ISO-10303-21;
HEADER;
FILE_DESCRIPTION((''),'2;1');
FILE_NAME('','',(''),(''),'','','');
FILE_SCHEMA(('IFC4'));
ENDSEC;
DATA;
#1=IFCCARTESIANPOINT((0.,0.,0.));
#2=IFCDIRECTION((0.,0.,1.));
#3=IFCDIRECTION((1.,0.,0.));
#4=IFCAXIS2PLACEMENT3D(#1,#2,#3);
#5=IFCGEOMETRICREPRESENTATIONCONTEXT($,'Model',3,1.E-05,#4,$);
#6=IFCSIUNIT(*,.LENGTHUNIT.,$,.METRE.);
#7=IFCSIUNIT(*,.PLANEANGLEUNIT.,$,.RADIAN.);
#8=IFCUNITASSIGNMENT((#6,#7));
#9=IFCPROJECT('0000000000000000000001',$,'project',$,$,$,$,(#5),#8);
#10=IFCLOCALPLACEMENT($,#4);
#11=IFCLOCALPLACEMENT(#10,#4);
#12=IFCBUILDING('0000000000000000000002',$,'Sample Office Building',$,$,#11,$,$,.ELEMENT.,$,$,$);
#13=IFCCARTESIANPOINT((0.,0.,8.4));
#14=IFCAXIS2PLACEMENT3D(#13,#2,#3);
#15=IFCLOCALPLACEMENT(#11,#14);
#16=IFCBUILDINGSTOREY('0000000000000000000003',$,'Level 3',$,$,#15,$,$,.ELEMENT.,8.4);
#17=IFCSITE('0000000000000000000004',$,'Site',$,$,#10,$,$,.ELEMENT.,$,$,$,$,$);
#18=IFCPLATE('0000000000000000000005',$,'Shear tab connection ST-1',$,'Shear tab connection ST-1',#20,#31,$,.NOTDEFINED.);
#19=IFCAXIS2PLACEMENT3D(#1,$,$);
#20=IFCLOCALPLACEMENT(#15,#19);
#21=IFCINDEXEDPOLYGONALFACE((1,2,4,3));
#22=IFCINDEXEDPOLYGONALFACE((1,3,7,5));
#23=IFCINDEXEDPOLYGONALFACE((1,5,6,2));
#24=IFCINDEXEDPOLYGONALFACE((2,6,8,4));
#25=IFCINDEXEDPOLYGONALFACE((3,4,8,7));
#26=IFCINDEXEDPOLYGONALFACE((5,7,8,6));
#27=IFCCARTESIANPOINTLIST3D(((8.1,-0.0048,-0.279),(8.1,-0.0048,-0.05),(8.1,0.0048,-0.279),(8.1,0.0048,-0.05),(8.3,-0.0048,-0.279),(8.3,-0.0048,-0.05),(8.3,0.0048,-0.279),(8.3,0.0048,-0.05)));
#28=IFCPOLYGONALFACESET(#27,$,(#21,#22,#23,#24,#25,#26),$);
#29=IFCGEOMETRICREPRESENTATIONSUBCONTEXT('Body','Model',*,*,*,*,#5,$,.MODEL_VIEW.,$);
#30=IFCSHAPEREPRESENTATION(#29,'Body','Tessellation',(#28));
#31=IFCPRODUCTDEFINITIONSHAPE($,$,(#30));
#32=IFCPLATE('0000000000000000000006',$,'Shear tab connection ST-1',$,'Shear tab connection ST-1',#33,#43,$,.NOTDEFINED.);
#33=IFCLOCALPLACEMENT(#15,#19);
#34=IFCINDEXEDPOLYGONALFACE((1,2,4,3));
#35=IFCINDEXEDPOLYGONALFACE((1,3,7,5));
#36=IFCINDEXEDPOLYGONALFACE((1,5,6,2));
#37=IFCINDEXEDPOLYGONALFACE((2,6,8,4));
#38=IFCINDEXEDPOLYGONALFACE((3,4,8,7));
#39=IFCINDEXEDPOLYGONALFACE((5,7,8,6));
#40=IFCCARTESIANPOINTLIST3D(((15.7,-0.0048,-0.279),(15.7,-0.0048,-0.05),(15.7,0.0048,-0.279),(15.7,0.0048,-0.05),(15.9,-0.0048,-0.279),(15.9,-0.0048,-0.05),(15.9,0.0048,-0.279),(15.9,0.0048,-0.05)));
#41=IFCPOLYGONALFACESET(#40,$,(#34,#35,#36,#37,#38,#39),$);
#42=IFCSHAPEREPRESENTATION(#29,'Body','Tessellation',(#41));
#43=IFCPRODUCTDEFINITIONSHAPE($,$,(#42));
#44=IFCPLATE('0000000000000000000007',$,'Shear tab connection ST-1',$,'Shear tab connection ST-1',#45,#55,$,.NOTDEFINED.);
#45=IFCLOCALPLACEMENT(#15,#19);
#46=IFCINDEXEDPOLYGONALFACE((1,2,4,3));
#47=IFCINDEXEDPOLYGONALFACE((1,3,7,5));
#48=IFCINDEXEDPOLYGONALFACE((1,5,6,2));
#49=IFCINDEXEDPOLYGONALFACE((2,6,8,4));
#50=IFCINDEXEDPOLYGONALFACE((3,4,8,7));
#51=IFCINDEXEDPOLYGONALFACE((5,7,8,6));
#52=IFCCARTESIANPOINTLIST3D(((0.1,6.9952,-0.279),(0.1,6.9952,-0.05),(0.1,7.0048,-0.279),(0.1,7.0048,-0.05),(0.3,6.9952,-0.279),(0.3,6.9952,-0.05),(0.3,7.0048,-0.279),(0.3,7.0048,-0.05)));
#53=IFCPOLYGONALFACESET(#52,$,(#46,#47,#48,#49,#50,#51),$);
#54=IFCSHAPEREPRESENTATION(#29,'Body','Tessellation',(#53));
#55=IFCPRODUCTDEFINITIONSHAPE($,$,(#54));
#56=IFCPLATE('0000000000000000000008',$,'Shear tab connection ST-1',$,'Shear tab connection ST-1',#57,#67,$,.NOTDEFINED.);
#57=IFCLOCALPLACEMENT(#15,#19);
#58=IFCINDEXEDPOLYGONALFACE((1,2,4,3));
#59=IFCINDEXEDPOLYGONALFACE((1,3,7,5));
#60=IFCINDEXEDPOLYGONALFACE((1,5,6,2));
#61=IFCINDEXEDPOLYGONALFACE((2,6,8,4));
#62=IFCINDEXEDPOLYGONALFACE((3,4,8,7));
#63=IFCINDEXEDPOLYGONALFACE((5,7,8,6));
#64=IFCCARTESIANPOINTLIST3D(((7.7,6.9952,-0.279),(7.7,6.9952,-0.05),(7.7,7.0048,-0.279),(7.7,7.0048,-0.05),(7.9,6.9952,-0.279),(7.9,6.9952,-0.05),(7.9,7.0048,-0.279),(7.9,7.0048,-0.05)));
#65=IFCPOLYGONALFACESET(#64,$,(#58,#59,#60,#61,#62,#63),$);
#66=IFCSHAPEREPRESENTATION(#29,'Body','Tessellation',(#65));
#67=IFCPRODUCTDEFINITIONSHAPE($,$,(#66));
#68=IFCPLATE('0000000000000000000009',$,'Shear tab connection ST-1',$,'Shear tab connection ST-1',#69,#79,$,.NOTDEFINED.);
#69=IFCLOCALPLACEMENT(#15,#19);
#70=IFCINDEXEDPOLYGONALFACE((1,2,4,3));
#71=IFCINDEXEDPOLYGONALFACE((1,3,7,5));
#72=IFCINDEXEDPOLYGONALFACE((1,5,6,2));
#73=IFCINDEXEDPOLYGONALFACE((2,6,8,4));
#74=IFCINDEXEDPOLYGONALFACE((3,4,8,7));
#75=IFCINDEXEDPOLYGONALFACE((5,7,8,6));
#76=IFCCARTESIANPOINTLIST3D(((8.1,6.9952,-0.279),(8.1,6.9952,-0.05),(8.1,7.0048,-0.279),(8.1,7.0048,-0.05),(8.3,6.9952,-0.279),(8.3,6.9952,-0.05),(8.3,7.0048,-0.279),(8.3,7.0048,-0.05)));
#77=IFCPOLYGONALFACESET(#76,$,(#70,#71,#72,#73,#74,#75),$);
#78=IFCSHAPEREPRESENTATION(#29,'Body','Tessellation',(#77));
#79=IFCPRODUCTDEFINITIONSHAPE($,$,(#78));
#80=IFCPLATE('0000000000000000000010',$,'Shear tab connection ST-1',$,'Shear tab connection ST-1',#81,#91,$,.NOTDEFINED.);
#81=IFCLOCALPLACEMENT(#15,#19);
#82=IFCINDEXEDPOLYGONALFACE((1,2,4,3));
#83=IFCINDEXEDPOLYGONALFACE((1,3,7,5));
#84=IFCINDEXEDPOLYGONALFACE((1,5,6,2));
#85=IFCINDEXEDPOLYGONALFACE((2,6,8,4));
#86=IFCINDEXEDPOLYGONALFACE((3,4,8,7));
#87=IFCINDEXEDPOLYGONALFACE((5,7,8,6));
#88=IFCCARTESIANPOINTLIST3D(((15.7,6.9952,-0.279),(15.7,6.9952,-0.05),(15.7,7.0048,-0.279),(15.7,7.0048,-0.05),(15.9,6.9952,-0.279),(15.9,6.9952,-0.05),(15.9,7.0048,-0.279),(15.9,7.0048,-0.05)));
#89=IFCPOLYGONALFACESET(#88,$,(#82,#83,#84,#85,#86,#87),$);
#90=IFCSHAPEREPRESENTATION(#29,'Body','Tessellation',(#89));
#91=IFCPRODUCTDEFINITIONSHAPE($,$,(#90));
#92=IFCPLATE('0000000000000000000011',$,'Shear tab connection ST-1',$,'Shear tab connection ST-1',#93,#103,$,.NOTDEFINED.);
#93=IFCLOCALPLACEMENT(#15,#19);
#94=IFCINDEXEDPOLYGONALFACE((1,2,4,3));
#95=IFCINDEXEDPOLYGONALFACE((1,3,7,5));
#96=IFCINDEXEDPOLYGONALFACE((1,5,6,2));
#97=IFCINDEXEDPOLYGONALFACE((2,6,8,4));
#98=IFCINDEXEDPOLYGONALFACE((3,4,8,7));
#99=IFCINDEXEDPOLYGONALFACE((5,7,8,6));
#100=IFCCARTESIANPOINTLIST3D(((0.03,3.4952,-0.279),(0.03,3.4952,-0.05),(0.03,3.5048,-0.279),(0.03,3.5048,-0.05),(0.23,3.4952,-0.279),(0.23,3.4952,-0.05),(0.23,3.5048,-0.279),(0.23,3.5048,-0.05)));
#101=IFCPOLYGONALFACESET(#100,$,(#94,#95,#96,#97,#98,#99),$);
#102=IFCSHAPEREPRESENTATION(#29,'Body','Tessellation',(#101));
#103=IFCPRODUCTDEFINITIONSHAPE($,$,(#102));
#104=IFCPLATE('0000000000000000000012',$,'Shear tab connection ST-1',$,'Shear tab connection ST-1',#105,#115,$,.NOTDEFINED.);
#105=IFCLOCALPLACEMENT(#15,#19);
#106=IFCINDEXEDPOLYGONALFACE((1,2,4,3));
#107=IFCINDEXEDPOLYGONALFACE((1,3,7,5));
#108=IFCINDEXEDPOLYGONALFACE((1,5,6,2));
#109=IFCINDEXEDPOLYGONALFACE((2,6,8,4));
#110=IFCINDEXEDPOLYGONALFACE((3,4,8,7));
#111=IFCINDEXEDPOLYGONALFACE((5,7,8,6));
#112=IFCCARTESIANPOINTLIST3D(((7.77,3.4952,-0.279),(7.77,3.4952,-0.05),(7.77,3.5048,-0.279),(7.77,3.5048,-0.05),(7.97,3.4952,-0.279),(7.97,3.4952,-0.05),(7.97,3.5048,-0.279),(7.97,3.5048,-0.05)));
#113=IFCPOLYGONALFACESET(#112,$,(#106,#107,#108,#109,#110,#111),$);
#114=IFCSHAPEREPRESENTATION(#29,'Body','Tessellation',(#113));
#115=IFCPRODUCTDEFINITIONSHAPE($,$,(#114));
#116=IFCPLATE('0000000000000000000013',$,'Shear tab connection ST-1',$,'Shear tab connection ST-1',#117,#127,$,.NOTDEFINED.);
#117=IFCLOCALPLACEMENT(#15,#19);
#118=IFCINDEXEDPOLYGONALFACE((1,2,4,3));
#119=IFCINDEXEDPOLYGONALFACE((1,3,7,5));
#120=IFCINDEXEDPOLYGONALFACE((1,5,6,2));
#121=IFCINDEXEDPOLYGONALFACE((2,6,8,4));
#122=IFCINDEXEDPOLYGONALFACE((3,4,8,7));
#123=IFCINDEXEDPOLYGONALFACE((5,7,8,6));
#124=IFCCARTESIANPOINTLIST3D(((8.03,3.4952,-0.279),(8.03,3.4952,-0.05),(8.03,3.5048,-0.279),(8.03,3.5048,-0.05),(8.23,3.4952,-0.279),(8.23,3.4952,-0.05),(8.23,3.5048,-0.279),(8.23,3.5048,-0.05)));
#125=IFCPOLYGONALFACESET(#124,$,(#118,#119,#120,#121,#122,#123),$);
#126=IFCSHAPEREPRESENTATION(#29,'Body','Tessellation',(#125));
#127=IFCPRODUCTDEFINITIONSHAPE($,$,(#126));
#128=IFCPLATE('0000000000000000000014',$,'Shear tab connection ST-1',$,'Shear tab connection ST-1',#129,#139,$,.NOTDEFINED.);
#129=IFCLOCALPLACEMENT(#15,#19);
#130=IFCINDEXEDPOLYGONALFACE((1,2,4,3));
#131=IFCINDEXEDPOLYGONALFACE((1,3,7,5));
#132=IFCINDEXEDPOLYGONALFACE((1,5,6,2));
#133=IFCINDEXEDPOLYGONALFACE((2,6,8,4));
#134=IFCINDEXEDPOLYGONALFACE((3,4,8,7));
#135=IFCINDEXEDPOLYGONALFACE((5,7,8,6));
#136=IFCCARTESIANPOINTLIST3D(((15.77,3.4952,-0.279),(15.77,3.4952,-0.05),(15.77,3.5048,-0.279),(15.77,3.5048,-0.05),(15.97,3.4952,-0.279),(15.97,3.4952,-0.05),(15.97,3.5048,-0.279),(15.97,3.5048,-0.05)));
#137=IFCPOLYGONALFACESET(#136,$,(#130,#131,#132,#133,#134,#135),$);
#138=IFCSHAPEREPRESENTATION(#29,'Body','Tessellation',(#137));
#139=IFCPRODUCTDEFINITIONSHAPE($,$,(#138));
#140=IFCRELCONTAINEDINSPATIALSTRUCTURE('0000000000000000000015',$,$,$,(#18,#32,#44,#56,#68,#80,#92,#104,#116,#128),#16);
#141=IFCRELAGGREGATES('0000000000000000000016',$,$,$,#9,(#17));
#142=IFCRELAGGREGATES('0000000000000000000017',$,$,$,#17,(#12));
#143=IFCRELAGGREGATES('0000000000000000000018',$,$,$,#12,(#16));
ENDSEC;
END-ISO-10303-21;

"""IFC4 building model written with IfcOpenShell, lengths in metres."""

from ifc_helpers import new_model, si_unit, frame, origin_with_axes, place, context, subcontext, project, spatial, rectangle, extrude, element, save


model = new_model("IFC4")

# Units and contexts
model_context = context("Model", 3, precision=1e-05, world=origin_with_axes())
body_context = subcontext(model_context, "Body", "Model", "MODEL_VIEW")
ifc_project = project(units=[si_unit("LENGTHUNIT", "METRE"), si_unit("PLANEANGLEUNIT", "RADIAN")], contexts=[model_context])

# Site, building, storey
site_placement = place(None, origin_with_axes())
site = spatial("IfcSite", under=ifc_project, at=site_placement, Name="Site", CompositionType="ELEMENT")
building_placement = place(site_placement, origin_with_axes())
building = spatial("IfcBuilding", under=site, at=building_placement, Name="Sample Office Building", CompositionType="ELEMENT")
storey_placement = place(building_placement, frame((0.0, 0.0, 8.4), z_axis=(0.0, 0.0, 1.0), x_axis=(1.0, 0.0, 0.0)))
storey = spatial("IfcBuildingStorey", under=building, at=storey_placement, Name="Level 3", CompositionType="ELEMENT", Elevation=8.4)

# Plates
for number, where, z_axis, x_axis, name in (
    (1, (8.2, 0.0, 8.121), (0.0, 0.0, 1.0), (1.0, 0.0, 0.0), "Shear tab connection ST-1"),
    (2, (15.8, 0.0, 8.121), (0.0, 0.0, 1.0), (1.0, 0.0, 0.0), "Shear tab connection ST-1"),
):
    element("IfcPlate", number, at=place(None, frame(where, z_axis=z_axis, x_axis=x_axis)), inside=storey, Name=name, ObjectType="Shear tab connection ST-1", PredefinedType="NOTDEFINED", context=body_context, shape_type="SweptSolid", body=[
        extrude(rectangle(XDim=0.2, YDim=0.0095), None, (0.0, 0.0, 1.0), 0.229),
    ])
plate_1_placement = place(None, frame((0.2, 7.0, 8.121), z_axis=(0.0, 0.0, 1.0), x_axis=(1.0, 0.0, 0.0)))
element("IfcPlate", 3, at=plate_1_placement, inside=storey, Name="Shear tab connection ST-1", ObjectType="Shear tab connection ST-1", PredefinedType="NOTDEFINED", context=body_context, shape_type="SweptSolid", body=[
    extrude(rectangle(XDim=0.2, YDim=0.0095), None, (0.0, 0.0, 1.0), 0.229),
])
plate_2_placement = place(None, frame((7.8, 7.0, 8.121), z_axis=(0.0, 0.0, 1.0), x_axis=(1.0, 0.0, 0.0)))
element("IfcPlate", 4, at=plate_2_placement, inside=storey, Name="Shear tab connection ST-1", ObjectType="Shear tab connection ST-1", PredefinedType="NOTDEFINED", context=body_context, shape_type="SweptSolid", body=[
    extrude(rectangle(XDim=0.2, YDim=0.0095), None, (0.0, 0.0, 1.0), 0.229),
])
for number, where, z_axis, x_axis, name in (
    (5, (8.2, 7.0, 8.121), (0.0, 0.0, 1.0), (1.0, 0.0, 0.0), "Shear tab connection ST-1"),
    (6, (15.8, 7.0, 8.121), (0.0, 0.0, 1.0), (1.0, 0.0, 0.0), "Shear tab connection ST-1"),
):
    element("IfcPlate", number, at=place(None, frame(where, z_axis=z_axis, x_axis=x_axis)), inside=storey, Name=name, ObjectType="Shear tab connection ST-1", PredefinedType="NOTDEFINED", context=body_context, shape_type="SweptSolid", body=[
        extrude(rectangle(XDim=0.2, YDim=0.0095), None, (0.0, 0.0, 1.0), 0.229),
    ])
plate_3_placement = place(None, frame((0.13, 3.5, 8.121), z_axis=(0.0, 0.0, 1.0), x_axis=(1.0, 0.0, 0.0)))
element("IfcPlate", 7, at=plate_3_placement, inside=storey, Name="Shear tab connection ST-1", ObjectType="Shear tab connection ST-1", PredefinedType="NOTDEFINED", context=body_context, shape_type="SweptSolid", body=[
    extrude(rectangle(XDim=0.2, YDim=0.0095), None, (0.0, 0.0, 1.0), 0.229),
])
plate_4_placement = place(None, frame((7.87, 3.5, 8.121), z_axis=(0.0, 0.0, 1.0), x_axis=(1.0, 0.0, 0.0)))
element("IfcPlate", 8, at=plate_4_placement, inside=storey, Name="Shear tab connection ST-1", ObjectType="Shear tab connection ST-1", PredefinedType="NOTDEFINED", context=body_context, shape_type="SweptSolid", body=[
    extrude(rectangle(XDim=0.2, YDim=0.0095), None, (0.0, 0.0, 1.0), 0.229),
])
for number, where, z_axis, x_axis, name in (
    (9, (8.13, 3.5, 8.121), (0.0, 0.0, 1.0), (1.0, 0.0, 0.0), "Shear tab connection ST-1"),
    (10, (15.87, 3.5, 8.121), (0.0, 0.0, 1.0), (1.0, 0.0, 0.0), "Shear tab connection ST-1"),
):
    element("IfcPlate", number, at=place(None, frame(where, z_axis=z_axis, x_axis=x_axis)), inside=storey, Name=name, ObjectType="Shear tab connection ST-1", PredefinedType="NOTDEFINED", context=body_context, shape_type="SweptSolid", body=[
        extrude(rectangle(XDim=0.2, YDim=0.0095), None, (0.0, 0.0, 1.0), 0.229),
    ])

save(model, "model.ifc")
